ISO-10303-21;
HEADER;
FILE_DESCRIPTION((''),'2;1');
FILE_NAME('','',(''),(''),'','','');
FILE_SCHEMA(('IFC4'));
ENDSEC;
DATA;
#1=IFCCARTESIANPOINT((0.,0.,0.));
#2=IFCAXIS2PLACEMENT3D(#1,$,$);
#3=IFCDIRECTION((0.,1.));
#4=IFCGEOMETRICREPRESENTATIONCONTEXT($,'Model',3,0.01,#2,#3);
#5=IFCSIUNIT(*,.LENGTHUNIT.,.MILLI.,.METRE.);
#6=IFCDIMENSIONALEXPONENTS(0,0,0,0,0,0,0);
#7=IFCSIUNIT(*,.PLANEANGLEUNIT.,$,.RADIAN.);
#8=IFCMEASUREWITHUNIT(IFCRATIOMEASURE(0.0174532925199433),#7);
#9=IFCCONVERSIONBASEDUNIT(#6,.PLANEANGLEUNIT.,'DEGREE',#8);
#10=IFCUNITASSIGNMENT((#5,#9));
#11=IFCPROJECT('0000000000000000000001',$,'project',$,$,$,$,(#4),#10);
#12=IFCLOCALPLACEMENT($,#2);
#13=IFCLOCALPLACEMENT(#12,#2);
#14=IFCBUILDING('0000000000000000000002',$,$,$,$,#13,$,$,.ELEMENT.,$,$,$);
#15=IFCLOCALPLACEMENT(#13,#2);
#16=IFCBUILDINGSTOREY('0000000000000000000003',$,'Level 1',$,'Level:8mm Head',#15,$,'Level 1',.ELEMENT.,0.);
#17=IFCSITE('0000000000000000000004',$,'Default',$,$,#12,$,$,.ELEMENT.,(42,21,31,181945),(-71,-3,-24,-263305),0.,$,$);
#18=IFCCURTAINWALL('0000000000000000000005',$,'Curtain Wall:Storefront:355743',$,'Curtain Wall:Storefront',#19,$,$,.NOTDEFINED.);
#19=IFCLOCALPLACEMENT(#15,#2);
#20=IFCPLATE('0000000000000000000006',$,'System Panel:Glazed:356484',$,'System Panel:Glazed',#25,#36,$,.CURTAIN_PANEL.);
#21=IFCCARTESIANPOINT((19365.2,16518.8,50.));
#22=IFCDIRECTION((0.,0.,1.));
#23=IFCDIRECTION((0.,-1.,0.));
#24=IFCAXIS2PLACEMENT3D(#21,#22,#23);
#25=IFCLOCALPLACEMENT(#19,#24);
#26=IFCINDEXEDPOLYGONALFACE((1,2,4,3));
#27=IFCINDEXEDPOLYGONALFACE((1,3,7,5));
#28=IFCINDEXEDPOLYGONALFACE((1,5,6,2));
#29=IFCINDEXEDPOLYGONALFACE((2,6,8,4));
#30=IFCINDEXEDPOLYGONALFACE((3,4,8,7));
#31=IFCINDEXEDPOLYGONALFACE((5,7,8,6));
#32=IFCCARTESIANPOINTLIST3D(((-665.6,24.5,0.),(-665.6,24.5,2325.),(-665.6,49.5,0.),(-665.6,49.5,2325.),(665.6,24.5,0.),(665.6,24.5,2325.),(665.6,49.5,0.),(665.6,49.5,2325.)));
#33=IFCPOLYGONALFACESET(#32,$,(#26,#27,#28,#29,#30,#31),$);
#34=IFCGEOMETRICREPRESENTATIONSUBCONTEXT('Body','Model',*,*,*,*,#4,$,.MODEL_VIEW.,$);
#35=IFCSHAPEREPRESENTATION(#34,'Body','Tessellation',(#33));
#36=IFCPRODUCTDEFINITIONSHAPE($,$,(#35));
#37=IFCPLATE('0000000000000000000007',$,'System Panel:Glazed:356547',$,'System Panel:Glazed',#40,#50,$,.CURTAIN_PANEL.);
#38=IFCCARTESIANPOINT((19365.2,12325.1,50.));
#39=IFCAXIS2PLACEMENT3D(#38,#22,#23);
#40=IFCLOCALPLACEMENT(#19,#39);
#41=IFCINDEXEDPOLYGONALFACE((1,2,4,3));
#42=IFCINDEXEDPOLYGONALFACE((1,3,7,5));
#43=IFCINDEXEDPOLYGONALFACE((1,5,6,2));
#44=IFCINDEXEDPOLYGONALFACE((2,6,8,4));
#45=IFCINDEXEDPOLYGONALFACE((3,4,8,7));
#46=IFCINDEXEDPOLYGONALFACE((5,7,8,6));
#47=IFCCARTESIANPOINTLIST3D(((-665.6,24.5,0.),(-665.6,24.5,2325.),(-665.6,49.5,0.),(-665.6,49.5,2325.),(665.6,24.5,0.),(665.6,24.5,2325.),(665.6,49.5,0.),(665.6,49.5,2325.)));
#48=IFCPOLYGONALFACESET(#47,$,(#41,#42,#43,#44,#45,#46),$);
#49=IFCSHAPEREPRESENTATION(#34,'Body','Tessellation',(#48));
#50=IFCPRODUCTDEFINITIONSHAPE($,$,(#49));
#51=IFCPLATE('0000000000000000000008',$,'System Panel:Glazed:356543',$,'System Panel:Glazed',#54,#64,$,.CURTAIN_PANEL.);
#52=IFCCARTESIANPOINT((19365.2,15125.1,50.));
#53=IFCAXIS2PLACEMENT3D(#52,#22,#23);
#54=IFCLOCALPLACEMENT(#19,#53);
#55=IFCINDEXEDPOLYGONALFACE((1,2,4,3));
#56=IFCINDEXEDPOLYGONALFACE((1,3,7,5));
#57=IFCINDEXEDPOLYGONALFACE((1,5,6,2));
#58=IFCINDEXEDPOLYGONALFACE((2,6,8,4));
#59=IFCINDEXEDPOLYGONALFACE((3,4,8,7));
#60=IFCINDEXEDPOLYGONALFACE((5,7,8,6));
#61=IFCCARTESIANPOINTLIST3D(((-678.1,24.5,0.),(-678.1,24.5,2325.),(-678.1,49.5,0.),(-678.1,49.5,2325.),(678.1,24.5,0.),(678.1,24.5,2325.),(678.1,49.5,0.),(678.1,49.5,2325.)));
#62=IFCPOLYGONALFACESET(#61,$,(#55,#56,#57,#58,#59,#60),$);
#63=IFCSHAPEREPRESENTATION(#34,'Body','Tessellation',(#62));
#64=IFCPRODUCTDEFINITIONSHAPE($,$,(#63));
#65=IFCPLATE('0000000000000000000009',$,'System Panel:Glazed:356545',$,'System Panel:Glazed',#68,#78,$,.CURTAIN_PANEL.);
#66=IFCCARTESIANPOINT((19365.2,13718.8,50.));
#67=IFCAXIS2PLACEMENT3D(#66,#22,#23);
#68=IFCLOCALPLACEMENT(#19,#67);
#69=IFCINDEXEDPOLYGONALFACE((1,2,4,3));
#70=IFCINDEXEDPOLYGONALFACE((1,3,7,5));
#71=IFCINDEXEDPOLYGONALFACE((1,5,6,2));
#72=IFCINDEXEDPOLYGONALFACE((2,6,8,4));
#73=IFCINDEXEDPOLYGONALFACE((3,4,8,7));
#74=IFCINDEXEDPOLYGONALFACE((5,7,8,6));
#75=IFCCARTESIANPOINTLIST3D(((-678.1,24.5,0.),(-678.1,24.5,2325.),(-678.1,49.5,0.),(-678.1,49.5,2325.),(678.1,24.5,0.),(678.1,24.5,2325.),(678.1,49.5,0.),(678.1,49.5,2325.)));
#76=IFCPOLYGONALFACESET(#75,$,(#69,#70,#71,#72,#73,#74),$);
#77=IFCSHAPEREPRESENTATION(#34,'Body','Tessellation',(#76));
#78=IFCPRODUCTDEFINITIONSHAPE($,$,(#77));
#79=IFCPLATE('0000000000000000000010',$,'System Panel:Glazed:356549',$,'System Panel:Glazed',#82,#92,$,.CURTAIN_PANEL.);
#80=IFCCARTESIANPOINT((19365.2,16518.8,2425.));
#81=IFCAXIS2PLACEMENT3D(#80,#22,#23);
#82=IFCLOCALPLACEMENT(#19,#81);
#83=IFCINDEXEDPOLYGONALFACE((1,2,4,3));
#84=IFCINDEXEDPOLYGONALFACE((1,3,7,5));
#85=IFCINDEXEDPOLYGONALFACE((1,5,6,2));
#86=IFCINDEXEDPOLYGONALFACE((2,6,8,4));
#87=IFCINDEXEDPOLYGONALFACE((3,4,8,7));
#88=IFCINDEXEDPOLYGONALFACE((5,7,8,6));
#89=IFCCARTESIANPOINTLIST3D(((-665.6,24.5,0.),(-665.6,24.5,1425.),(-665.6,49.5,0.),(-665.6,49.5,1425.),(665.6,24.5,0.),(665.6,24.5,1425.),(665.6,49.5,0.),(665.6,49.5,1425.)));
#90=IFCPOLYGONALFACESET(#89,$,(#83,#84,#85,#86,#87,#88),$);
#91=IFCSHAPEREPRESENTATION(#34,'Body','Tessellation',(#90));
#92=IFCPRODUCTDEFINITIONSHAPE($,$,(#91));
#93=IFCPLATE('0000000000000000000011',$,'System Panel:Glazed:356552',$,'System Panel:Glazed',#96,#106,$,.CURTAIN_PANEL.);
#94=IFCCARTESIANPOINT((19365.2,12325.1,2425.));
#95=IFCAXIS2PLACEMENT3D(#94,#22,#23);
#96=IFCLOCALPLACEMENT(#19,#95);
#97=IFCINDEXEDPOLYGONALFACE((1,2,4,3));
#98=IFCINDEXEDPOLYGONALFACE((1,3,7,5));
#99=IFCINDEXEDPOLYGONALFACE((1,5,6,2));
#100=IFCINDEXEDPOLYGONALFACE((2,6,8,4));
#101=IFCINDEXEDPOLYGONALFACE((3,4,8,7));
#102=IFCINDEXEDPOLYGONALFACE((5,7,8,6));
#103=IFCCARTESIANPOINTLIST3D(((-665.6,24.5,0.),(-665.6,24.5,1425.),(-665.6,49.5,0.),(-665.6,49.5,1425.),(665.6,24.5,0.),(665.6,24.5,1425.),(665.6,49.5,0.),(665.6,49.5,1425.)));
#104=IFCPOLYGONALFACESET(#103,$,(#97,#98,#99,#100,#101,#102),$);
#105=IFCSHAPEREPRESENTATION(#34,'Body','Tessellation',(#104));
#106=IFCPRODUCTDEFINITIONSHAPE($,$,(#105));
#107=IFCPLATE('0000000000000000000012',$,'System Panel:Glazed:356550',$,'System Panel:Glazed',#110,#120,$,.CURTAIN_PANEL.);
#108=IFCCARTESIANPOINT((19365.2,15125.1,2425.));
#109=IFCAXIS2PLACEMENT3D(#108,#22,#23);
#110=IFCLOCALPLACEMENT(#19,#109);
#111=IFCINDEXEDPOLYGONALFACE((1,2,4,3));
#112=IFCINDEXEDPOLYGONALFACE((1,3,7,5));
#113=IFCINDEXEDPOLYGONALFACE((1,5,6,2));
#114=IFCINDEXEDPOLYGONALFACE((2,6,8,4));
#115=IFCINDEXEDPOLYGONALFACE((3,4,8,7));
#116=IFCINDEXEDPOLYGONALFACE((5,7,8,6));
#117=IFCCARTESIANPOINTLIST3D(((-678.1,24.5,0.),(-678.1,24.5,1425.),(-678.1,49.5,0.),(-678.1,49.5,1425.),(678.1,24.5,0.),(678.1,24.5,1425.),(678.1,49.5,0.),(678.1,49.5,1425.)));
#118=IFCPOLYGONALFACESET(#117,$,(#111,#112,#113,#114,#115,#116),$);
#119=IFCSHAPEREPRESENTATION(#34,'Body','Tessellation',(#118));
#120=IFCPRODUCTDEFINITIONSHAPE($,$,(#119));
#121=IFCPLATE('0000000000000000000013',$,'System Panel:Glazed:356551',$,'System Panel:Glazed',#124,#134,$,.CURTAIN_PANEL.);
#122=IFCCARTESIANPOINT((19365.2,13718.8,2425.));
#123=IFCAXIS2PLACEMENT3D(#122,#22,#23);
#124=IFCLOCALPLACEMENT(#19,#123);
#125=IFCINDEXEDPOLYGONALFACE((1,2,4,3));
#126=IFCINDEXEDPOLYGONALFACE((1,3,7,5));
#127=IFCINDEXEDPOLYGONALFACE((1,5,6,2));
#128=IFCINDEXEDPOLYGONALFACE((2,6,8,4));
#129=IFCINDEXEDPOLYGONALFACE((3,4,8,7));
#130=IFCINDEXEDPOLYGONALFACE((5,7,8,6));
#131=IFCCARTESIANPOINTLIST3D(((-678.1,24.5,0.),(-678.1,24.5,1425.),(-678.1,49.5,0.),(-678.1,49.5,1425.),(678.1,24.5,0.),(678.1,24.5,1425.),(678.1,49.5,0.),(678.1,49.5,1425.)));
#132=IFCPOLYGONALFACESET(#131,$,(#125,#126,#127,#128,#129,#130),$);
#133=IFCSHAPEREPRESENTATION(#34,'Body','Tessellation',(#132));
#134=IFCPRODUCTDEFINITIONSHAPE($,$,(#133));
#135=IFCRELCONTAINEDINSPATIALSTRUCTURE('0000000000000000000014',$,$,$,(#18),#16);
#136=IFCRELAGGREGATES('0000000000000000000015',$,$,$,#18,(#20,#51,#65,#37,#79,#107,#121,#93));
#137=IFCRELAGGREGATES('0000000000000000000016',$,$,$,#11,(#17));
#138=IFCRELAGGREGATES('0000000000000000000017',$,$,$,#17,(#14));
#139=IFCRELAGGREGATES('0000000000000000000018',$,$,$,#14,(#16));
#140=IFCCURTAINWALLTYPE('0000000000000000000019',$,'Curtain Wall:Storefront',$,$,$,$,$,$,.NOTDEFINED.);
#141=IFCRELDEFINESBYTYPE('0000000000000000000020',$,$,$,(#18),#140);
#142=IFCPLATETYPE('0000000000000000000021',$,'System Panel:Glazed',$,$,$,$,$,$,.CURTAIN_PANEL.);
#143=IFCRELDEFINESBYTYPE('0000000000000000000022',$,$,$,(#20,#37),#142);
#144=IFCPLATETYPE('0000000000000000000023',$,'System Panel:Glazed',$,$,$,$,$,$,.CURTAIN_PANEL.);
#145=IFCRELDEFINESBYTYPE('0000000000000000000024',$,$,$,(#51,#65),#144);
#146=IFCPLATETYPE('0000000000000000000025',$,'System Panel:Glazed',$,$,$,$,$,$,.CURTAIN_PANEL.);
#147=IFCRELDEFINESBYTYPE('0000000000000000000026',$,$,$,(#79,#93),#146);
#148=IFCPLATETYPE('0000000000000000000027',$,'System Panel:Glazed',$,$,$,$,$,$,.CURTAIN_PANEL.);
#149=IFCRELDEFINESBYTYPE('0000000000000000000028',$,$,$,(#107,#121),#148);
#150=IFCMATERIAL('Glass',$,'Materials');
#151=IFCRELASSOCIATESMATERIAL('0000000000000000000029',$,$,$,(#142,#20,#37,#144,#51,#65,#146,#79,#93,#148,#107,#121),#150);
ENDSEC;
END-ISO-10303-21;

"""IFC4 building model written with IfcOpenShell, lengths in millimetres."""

from ifc_helpers import new_model, entity, si_unit, converted_unit, direction, frame, origin, place, context, subcontext, project, spatial, indexed_curve, outline, extrude, shape, source, transform, mapped, material, type_object, type_shapes, element, aggregate, save


model = new_model("IFC4")

# Units and contexts
model_context = context("Model", 3, precision=0.01, world=origin(), true_north=direction((0.0, 1.0)))
body_context = subcontext(model_context, "Body", "Model", "MODEL_VIEW")
footprint_context = subcontext(model_context, "FootPrint", "Model", "MODEL_VIEW")
ifc_project = project(units=[si_unit("LENGTHUNIT", "METRE", prefix="MILLI"), converted_unit("PLANEANGLEUNIT", "DEGREE", entity("IfcRatioMeasure", 0.0174532925199433), si_unit("PLANEANGLEUNIT", "RADIAN"), dimensions=[0, 0, 0, 0, 0, 0, 0])], contexts=[model_context])

# Site, building, storey
site_placement = place(None, origin())
site = spatial("IfcSite", under=ifc_project, at=site_placement, Name="Default", CompositionType="ELEMENT", RefLatitude=(42, 21, 31, 181945), RefLongitude=(-71, -3, -24, -263305), RefElevation=0.0)
building_placement = place(site_placement, origin())
building = spatial("IfcBuilding", under=site, at=building_placement, CompositionType="ELEMENT")
storey_placement = place(building_placement, origin())
storey = spatial("IfcBuildingStorey", under=building, at=storey_placement, Name="Level 1", ObjectType="Level:8mm Head", LongName="Level 1", CompositionType="ELEMENT", Elevation=0.0)

# Curtain wall, plates
curtain_wall_type = type_object("IfcCurtainWallType", Name="Curtain Wall:Storefront", PredefinedType="NOTDEFINED")
curtain_wall_placement = place(storey_placement, origin())
curtain_wall = element("IfcCurtainWall", 1, at=curtain_wall_placement, inside=storey, type_object=curtain_wall_type, Name="Curtain Wall:Storefront:355743", ObjectType="Curtain Wall:Storefront", PredefinedType="NOTDEFINED")
ifc_material_1 = material(Name="Glass", Category="Materials")
plate_type_1 = type_object("IfcPlateType", Name="System Panel:Glazed", PredefinedType="CURTAIN_PANEL", material=ifc_material_1)
shared_shape_1 = source(origin(), body_context, "Body", "SweptSolid", [
    extrude(outline(indexed_curve([(-12.5, -665.6), (12.5, -665.6), (12.5, 665.6), (-12.5, 665.6), (-12.5, -665.6)], self_intersect=False)), frame((0.0, 37.0, 0.0), z_axis=(0.0, 0.0, 1.0), x_axis=(0.0, 1.0, 0.0)), (0.0, 0.0, 1.0), 2325.0),
])
shared_shape_2 = source(origin(), footprint_context, "FootPrint", "Curve2D", [
    entity("IfcIndexedPolyCurve", entity("IfcCartesianPointList2D", [[665.6, 24.5], [665.6, 49.5], [-665.6, 49.5], [-665.6, 24.5], [665.6, 24.5]]), None, False),
])
type_shapes(plate_type_1, [shared_shape_1, shared_shape_2])
plate_1_placement = place(curtain_wall_placement, frame((19365.2, 16518.8, 50.0), z_axis=(0.0, 0.0, 1.0), x_axis=(0.0, -1.0, 0.0)))
plate_1 = element("IfcPlate", 2, at=plate_1_placement, type_object=plate_type_1, material=ifc_material_1, Name="System Panel:Glazed:356484", ObjectType="System Panel:Glazed", PredefinedType="CURTAIN_PANEL", shapes=[
    shape(body_context, "Body", "MappedRepresentation", [mapped(shared_shape_1, transform((0.0, 0.0, 0.0), scale=1.0))]),
    shape(body_context, "Body", "MappedRepresentation", [mapped(shared_shape_2, transform((0.0, 0.0, 0.0), scale=1.0))]),
])
plate_2_placement = place(curtain_wall_placement, frame((19365.2, 12325.1, 50.0), z_axis=(0.0, 0.0, 1.0), x_axis=(0.0, -1.0, 0.0)))
plate_2 = element("IfcPlate", 3, at=plate_2_placement, type_object=plate_type_1, material=ifc_material_1, Name="System Panel:Glazed:356547", ObjectType="System Panel:Glazed", PredefinedType="CURTAIN_PANEL", shapes=[
    shape(body_context, "Body", "MappedRepresentation", [mapped(shared_shape_1, transform((0.0, 0.0, 0.0), scale=1.0))]),
    shape(body_context, "Body", "MappedRepresentation", [mapped(shared_shape_2, transform((0.0, 0.0, 0.0), scale=1.0))]),
])
plate_type_2 = type_object("IfcPlateType", Name="System Panel:Glazed", PredefinedType="CURTAIN_PANEL", material=ifc_material_1)
shared_shape_3 = source(origin(), body_context, "Body", "SweptSolid", [
    extrude(outline(indexed_curve([(-12.5, -678.1), (12.5, -678.1), (12.5, 678.1), (-12.5, 678.1), (-12.5, -678.1)], self_intersect=False)), frame((0.0, 37.0, 0.0), z_axis=(0.0, 0.0, 1.0), x_axis=(0.0, 1.0, 0.0)), (0.0, 0.0, 1.0), 2325.0),
])
shared_shape_4 = source(origin(), footprint_context, "FootPrint", "Curve2D", [
    entity("IfcIndexedPolyCurve", entity("IfcCartesianPointList2D", [[678.1, 24.5], [678.1, 49.5], [-678.1, 49.5], [-678.1, 24.5], [678.1, 24.5]]), None, False),
])
type_shapes(plate_type_2, [shared_shape_3, shared_shape_4])
plate_3_placement = place(curtain_wall_placement, frame((19365.2, 15125.1, 50.0), z_axis=(0.0, 0.0, 1.0), x_axis=(0.0, -1.0, 0.0)))
plate_3 = element("IfcPlate", 4, at=plate_3_placement, type_object=plate_type_2, material=ifc_material_1, Name="System Panel:Glazed:356543", ObjectType="System Panel:Glazed", PredefinedType="CURTAIN_PANEL", shapes=[
    shape(body_context, "Body", "MappedRepresentation", [mapped(shared_shape_3, transform((0.0, 0.0, 0.0), scale=1.0))]),
    shape(body_context, "Body", "MappedRepresentation", [mapped(shared_shape_4, transform((0.0, 0.0, 0.0), scale=1.0))]),
])
plate_4_placement = place(curtain_wall_placement, frame((19365.2, 13718.8, 50.0), z_axis=(0.0, 0.0, 1.0), x_axis=(0.0, -1.0, 0.0)))
plate_4 = element("IfcPlate", 5, at=plate_4_placement, type_object=plate_type_2, material=ifc_material_1, Name="System Panel:Glazed:356545", ObjectType="System Panel:Glazed", PredefinedType="CURTAIN_PANEL", shapes=[
    shape(body_context, "Body", "MappedRepresentation", [mapped(shared_shape_3, transform((0.0, 0.0, 0.0), scale=1.0))]),
    shape(body_context, "Body", "MappedRepresentation", [mapped(shared_shape_4, transform((0.0, 0.0, 0.0), scale=1.0))]),
])
plate_type_3 = type_object("IfcPlateType", Name="System Panel:Glazed", PredefinedType="CURTAIN_PANEL", material=ifc_material_1)
shared_shape_5 = source(origin(), body_context, "Body", "SweptSolid", [
    extrude(outline(indexed_curve([(-12.5, -665.6), (12.5, -665.6), (12.5, 665.6), (-12.5, 665.6), (-12.5, -665.6)], self_intersect=False)), frame((0.0, 37.0, 0.0), z_axis=(0.0, 0.0, 1.0), x_axis=(0.0, 1.0, 0.0)), (0.0, 0.0, 1.0), 1425.0),
])
shared_shape_6 = source(origin(), footprint_context, "FootPrint", "Curve2D", [
    entity("IfcIndexedPolyCurve", entity("IfcCartesianPointList2D", [[665.6, 24.5], [665.6, 49.5], [-665.6, 49.5], [-665.6, 24.5], [665.6, 24.5]]), None, False),
])
type_shapes(plate_type_3, [shared_shape_5, shared_shape_6])
plate_5_placement = place(curtain_wall_placement, frame((19365.2, 16518.8, 2425.0), z_axis=(0.0, 0.0, 1.0), x_axis=(0.0, -1.0, 0.0)))
plate_5 = element("IfcPlate", 6, at=plate_5_placement, type_object=plate_type_3, material=ifc_material_1, Name="System Panel:Glazed:356549", ObjectType="System Panel:Glazed", PredefinedType="CURTAIN_PANEL", shapes=[
    shape(body_context, "Body", "MappedRepresentation", [mapped(shared_shape_5, transform((0.0, 0.0, 0.0), scale=1.0))]),
    shape(body_context, "Body", "MappedRepresentation", [mapped(shared_shape_6, transform((0.0, 0.0, 0.0), scale=1.0))]),
])
plate_6_placement = place(curtain_wall_placement, frame((19365.2, 12325.1, 2425.0), z_axis=(0.0, 0.0, 1.0), x_axis=(0.0, -1.0, 0.0)))
plate_6 = element("IfcPlate", 7, at=plate_6_placement, type_object=plate_type_3, material=ifc_material_1, Name="System Panel:Glazed:356552", ObjectType="System Panel:Glazed", PredefinedType="CURTAIN_PANEL", shapes=[
    shape(body_context, "Body", "MappedRepresentation", [mapped(shared_shape_5, transform((0.0, 0.0, 0.0), scale=1.0))]),
    shape(body_context, "Body", "MappedRepresentation", [mapped(shared_shape_6, transform((0.0, 0.0, 0.0), scale=1.0))]),
])
plate_type_4 = type_object("IfcPlateType", Name="System Panel:Glazed", PredefinedType="CURTAIN_PANEL", material=ifc_material_1)
shared_shape_7 = source(origin(), body_context, "Body", "SweptSolid", [
    extrude(outline(indexed_curve([(-12.5, -678.1), (12.5, -678.1), (12.5, 678.1), (-12.5, 678.1), (-12.5, -678.1)], self_intersect=False)), frame((0.0, 37.0, 0.0), z_axis=(0.0, 0.0, 1.0), x_axis=(0.0, 1.0, 0.0)), (0.0, 0.0, 1.0), 1425.0),
])
shared_shape_8 = source(origin(), footprint_context, "FootPrint", "Curve2D", [
    entity("IfcIndexedPolyCurve", entity("IfcCartesianPointList2D", [[678.1, 24.5], [678.1, 49.5], [-678.1, 49.5], [-678.1, 24.5], [678.1, 24.5]]), None, False),
])
type_shapes(plate_type_4, [shared_shape_7, shared_shape_8])
plate_7_placement = place(curtain_wall_placement, frame((19365.2, 15125.1, 2425.0), z_axis=(0.0, 0.0, 1.0), x_axis=(0.0, -1.0, 0.0)))
plate_7 = element("IfcPlate", 8, at=plate_7_placement, type_object=plate_type_4, material=ifc_material_1, Name="System Panel:Glazed:356550", ObjectType="System Panel:Glazed", PredefinedType="CURTAIN_PANEL", shapes=[
    shape(body_context, "Body", "MappedRepresentation", [mapped(shared_shape_7, transform((0.0, 0.0, 0.0), scale=1.0))]),
    shape(body_context, "Body", "MappedRepresentation", [mapped(shared_shape_8, transform((0.0, 0.0, 0.0), scale=1.0))]),
])
plate_8_placement = place(curtain_wall_placement, frame((19365.2, 13718.8, 2425.0), z_axis=(0.0, 0.0, 1.0), x_axis=(0.0, -1.0, 0.0)))
plate_8 = element("IfcPlate", 9, at=plate_8_placement, type_object=plate_type_4, material=ifc_material_1, Name="System Panel:Glazed:356551", ObjectType="System Panel:Glazed", PredefinedType="CURTAIN_PANEL", shapes=[
    shape(body_context, "Body", "MappedRepresentation", [mapped(shared_shape_7, transform((0.0, 0.0, 0.0), scale=1.0))]),
    shape(body_context, "Body", "MappedRepresentation", [mapped(shared_shape_8, transform((0.0, 0.0, 0.0), scale=1.0))]),
])
aggregate(curtain_wall, [plate_1, plate_3, plate_4, plate_2, plate_5, plate_7, plate_8, plate_6])

save(model, "model.ifc")
